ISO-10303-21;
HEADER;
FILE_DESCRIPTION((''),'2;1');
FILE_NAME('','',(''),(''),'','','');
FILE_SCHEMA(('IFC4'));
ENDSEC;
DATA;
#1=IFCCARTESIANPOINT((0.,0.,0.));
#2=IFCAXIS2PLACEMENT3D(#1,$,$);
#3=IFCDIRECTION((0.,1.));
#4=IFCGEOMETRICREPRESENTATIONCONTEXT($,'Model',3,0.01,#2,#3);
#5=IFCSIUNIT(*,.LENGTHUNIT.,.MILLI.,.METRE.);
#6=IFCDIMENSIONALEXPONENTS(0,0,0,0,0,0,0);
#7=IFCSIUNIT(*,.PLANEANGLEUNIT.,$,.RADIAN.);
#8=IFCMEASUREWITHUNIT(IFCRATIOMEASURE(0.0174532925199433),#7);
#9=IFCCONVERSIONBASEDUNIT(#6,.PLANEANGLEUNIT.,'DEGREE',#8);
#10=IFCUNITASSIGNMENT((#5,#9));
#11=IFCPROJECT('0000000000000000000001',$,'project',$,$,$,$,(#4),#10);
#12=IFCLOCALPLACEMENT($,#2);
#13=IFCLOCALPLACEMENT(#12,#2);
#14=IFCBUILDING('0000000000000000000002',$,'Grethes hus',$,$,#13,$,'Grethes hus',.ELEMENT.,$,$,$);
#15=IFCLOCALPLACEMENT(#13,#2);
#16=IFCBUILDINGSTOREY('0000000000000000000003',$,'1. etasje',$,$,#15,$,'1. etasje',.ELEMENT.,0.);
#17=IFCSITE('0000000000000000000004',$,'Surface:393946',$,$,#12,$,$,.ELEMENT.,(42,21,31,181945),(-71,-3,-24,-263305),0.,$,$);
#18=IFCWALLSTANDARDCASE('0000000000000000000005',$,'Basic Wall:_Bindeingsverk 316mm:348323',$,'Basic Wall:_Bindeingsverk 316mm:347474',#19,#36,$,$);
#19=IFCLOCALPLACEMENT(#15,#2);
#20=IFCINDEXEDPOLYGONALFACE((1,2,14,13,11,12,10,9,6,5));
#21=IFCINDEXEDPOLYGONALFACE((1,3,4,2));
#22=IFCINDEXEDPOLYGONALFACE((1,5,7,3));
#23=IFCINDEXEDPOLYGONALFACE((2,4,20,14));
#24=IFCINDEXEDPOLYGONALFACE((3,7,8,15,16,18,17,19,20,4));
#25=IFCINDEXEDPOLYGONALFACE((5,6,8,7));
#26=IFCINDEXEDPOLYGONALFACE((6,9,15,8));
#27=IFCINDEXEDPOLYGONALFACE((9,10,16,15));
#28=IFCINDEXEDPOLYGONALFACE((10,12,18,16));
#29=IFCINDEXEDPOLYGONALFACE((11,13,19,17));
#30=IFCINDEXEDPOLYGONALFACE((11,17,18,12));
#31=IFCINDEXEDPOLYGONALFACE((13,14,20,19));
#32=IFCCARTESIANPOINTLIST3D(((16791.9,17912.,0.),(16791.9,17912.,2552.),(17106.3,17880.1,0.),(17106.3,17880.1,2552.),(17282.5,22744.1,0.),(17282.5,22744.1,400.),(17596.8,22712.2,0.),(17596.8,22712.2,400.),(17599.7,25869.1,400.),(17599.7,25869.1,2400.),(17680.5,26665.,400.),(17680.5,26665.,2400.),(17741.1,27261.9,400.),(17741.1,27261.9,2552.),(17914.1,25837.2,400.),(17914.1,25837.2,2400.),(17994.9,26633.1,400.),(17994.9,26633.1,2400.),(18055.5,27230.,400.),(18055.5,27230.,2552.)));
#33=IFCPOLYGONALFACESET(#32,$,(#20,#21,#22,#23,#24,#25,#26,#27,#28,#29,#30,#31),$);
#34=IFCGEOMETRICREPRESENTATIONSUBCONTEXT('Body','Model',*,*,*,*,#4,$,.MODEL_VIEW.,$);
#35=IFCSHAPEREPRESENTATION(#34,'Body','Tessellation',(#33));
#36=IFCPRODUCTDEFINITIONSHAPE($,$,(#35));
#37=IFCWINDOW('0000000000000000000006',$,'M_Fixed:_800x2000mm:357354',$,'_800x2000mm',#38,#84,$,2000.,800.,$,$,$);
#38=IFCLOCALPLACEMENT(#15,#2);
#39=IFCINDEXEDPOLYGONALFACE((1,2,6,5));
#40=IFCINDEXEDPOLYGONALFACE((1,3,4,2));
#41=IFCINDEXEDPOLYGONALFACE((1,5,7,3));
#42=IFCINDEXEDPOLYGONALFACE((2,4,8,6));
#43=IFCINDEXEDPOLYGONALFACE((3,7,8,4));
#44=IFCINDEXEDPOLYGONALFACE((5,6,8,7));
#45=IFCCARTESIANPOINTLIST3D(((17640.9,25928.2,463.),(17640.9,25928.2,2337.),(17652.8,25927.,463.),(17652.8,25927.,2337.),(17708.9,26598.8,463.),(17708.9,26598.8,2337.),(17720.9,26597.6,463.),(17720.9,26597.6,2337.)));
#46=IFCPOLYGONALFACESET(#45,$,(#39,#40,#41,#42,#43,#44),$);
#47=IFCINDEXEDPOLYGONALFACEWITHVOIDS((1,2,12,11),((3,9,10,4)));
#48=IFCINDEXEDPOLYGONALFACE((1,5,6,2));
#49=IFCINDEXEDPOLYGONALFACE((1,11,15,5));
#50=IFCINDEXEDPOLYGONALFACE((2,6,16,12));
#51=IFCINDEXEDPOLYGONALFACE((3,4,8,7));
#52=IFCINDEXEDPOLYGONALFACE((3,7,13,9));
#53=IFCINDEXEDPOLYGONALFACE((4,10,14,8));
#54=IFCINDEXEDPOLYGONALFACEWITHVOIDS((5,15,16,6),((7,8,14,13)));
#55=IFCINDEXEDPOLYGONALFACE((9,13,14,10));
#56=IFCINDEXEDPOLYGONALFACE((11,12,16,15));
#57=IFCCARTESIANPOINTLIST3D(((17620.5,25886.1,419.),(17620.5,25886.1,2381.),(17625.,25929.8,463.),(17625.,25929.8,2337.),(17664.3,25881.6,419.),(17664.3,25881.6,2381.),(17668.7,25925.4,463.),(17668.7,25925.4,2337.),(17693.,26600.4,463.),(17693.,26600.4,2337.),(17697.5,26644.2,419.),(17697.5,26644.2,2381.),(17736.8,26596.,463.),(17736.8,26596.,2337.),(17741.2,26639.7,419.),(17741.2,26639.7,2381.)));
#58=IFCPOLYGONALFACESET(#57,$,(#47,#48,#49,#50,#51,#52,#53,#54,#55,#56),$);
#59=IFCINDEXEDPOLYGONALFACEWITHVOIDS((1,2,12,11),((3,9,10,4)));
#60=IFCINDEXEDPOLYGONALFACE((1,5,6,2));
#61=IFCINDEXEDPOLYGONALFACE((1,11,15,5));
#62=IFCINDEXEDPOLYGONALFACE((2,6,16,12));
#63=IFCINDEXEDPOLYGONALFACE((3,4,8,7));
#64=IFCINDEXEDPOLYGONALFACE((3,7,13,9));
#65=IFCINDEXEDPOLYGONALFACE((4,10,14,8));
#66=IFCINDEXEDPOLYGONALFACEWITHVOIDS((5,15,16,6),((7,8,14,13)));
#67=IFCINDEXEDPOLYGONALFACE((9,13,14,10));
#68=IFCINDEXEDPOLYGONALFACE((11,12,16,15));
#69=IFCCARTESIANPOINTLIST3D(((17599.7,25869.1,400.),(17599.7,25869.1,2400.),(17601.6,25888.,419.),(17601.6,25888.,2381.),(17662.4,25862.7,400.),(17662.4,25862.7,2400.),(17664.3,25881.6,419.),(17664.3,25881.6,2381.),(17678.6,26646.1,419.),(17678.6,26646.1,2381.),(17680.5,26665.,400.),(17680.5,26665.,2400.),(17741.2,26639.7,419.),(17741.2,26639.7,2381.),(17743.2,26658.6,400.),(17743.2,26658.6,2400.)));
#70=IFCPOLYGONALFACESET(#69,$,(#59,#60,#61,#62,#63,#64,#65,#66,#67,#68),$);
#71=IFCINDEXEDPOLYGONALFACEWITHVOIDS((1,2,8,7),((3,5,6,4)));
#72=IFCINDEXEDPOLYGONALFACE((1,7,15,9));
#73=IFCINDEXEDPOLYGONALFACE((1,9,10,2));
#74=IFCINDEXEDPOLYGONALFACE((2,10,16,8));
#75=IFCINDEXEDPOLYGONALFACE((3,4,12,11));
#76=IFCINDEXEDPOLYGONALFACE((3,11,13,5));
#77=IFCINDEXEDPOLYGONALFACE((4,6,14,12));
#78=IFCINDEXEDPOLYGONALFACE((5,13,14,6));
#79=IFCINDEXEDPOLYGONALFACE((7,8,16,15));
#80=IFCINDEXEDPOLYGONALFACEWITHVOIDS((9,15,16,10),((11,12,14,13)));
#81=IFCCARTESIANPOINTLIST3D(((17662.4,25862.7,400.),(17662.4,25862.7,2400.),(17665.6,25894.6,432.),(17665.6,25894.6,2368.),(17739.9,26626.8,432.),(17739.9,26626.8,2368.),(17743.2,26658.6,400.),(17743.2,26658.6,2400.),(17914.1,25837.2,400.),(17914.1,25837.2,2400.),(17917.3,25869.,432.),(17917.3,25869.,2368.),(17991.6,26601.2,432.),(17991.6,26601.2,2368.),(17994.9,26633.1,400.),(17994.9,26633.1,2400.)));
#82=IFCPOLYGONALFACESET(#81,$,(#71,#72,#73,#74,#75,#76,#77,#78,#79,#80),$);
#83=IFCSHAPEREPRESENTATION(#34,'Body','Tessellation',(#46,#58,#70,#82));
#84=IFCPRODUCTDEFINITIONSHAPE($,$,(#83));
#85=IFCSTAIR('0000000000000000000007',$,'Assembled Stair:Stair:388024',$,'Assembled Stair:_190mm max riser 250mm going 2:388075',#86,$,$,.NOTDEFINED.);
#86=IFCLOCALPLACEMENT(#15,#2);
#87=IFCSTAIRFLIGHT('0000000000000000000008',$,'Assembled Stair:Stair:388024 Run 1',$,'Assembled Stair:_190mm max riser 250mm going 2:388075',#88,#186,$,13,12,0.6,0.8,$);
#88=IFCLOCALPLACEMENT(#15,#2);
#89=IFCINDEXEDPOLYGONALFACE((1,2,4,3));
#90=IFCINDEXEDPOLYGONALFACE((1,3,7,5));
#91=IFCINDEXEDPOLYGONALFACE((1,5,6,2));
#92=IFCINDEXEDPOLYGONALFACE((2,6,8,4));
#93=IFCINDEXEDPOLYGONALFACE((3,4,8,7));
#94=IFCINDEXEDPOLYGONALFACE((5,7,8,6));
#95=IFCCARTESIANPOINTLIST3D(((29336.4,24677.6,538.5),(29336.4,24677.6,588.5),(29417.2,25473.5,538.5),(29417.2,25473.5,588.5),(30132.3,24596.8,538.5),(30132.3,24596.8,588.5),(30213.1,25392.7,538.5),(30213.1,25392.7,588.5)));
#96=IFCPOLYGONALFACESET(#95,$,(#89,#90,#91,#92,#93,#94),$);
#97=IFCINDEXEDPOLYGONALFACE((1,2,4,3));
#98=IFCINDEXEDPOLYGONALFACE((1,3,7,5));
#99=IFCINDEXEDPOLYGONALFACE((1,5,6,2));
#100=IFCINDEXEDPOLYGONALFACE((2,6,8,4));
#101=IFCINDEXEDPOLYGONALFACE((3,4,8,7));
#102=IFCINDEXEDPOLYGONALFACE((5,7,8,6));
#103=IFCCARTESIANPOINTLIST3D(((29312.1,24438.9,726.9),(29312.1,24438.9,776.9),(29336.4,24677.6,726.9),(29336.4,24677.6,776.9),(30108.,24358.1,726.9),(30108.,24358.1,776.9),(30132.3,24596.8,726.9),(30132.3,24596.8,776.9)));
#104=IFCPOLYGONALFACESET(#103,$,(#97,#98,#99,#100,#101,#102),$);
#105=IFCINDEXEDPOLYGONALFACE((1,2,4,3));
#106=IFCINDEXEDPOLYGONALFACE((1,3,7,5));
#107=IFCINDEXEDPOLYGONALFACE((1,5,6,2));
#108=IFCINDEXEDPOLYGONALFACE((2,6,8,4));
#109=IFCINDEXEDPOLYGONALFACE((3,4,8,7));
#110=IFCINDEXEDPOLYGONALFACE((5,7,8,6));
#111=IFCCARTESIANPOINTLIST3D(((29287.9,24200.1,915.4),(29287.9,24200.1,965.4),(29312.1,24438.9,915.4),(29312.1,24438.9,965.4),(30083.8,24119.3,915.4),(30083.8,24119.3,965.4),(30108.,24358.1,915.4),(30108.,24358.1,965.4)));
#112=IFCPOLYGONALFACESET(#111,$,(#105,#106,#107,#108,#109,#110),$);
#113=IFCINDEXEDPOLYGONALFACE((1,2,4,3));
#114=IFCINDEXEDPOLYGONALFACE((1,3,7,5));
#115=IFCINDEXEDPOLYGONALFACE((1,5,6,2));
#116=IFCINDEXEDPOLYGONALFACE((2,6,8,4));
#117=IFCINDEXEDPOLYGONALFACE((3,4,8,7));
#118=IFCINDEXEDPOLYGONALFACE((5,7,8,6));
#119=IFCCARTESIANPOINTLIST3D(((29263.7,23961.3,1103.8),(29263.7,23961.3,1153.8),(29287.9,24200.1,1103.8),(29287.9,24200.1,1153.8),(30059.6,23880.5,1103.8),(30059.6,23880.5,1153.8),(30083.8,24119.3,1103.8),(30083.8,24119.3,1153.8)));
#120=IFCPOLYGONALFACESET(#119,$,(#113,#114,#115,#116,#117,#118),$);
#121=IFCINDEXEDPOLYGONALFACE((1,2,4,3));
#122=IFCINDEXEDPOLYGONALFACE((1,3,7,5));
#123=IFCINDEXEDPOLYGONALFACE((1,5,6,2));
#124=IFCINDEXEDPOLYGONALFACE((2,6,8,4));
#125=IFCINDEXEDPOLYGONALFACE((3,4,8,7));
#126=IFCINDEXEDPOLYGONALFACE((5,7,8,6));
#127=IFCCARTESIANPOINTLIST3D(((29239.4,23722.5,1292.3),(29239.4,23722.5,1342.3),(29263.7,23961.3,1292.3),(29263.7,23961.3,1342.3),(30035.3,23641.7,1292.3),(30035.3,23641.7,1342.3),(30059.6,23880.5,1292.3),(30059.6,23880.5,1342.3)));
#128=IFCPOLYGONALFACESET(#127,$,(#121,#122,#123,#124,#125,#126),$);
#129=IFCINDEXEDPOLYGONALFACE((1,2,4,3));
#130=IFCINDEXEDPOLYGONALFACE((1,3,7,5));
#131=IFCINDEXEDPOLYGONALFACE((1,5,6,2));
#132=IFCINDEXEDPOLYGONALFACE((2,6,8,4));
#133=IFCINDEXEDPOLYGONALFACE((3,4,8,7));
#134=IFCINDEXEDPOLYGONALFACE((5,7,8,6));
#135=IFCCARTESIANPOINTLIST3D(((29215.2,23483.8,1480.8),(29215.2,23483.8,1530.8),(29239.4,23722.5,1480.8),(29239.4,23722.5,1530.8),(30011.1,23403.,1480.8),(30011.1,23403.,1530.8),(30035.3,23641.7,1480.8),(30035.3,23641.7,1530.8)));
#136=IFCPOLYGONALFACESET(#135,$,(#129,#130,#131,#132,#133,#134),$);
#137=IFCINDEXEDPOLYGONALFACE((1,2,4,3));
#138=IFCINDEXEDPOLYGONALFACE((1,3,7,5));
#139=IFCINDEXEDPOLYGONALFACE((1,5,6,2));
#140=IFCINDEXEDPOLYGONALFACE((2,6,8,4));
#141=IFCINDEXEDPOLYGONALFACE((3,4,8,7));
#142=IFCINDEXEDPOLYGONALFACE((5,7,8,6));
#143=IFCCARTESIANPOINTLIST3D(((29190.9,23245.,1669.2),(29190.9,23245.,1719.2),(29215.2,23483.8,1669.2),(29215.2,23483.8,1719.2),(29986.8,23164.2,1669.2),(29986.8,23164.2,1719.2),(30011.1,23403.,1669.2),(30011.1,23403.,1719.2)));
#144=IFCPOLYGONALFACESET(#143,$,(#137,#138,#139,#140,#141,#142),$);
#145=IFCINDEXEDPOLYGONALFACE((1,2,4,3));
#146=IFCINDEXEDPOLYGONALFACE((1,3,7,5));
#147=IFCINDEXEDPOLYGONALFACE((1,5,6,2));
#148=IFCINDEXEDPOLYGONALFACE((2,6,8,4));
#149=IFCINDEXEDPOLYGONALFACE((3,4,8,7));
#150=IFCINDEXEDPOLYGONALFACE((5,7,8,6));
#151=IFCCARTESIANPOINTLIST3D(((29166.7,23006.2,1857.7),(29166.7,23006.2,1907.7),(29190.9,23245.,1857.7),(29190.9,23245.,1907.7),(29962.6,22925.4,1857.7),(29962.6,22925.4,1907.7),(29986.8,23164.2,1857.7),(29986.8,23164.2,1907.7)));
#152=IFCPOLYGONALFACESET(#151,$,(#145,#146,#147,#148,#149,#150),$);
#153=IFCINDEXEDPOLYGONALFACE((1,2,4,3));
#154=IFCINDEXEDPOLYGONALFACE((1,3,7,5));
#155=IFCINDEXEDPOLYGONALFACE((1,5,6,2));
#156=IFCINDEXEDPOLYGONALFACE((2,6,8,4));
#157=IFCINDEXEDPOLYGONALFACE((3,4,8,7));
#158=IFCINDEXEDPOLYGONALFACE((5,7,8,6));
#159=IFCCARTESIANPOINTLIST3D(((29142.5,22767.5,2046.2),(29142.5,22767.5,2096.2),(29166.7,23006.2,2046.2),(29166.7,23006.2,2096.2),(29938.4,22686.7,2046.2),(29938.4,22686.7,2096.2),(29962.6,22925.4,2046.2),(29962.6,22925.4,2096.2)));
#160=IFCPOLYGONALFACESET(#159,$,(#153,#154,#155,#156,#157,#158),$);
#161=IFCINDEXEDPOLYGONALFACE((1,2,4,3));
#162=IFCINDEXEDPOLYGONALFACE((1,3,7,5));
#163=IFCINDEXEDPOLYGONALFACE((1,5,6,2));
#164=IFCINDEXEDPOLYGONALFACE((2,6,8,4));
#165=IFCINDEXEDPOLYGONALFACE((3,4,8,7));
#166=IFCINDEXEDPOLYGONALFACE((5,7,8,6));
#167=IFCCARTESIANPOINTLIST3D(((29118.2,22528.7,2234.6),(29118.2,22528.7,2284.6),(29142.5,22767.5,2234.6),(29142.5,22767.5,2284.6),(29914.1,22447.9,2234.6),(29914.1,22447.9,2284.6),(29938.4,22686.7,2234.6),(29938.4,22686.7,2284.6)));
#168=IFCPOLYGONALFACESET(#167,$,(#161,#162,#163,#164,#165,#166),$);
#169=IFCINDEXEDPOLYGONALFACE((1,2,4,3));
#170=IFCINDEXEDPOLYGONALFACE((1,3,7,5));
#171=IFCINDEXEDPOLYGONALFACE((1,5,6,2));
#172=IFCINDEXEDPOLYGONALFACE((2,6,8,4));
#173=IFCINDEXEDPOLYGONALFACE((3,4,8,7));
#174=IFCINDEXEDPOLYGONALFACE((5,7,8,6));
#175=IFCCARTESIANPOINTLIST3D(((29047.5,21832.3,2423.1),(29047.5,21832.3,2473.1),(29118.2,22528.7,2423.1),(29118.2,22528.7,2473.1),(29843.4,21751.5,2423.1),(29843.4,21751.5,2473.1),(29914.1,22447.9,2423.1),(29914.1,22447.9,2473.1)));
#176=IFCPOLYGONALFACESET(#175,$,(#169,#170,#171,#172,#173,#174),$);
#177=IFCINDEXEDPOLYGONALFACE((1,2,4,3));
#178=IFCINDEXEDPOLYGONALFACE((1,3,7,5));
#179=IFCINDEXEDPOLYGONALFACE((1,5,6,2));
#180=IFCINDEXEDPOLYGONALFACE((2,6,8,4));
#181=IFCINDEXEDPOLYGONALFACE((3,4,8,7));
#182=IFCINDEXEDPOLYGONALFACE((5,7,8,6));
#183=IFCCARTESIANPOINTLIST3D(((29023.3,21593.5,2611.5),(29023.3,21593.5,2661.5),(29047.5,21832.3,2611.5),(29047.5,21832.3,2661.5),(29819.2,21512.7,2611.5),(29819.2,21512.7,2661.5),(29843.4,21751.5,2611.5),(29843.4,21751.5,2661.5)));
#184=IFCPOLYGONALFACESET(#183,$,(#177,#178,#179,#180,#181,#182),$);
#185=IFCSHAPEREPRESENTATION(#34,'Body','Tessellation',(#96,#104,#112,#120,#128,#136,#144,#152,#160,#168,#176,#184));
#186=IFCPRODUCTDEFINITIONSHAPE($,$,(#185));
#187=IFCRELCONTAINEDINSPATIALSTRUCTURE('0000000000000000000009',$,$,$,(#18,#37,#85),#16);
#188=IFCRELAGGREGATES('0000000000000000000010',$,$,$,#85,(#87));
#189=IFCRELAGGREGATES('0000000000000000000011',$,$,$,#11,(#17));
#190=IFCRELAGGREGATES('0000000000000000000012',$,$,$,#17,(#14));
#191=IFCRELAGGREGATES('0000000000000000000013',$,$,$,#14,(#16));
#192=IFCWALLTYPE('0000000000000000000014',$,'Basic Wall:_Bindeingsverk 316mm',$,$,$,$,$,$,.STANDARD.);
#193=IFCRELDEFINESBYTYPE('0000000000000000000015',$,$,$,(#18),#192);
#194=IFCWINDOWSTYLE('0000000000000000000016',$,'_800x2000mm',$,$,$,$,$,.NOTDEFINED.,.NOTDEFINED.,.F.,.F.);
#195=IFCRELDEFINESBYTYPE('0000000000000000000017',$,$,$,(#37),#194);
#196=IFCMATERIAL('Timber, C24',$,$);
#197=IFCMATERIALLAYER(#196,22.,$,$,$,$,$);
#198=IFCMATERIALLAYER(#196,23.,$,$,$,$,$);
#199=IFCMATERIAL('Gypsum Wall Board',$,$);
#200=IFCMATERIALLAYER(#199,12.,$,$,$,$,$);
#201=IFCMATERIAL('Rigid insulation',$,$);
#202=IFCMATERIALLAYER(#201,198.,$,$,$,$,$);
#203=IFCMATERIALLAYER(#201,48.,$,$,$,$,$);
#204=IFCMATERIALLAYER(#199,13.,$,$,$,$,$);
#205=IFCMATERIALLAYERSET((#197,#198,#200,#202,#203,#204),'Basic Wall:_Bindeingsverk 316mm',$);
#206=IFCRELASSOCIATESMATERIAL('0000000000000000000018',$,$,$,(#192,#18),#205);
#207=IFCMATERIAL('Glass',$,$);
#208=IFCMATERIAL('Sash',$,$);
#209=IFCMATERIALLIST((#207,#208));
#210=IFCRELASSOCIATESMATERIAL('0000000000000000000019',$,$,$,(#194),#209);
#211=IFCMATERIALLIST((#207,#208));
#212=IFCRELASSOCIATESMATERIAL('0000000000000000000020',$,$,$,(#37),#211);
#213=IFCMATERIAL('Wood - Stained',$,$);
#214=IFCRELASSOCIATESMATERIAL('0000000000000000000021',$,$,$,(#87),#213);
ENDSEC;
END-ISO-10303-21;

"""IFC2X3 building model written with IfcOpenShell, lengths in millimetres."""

from ifc_helpers import new_model, entity, si_unit, converted_unit, direction, frame, frame_2d, origin, place, context, subcontext, project, spatial, polyline, rectangle, outline, extrude, clip, bounded_halfspace, source, transform, mapped, material, material_list, layer, layer_set, layer_usage, type_object, type_shapes, element, fill, aggregate, save


model = new_model("IFC2X3")

# Units and contexts
model_context = context("Model", 3, precision=0.01, world=origin(), true_north=direction((0.0, 1.0)))
body_context = subcontext(model_context, "Body", "Model", "MODEL_VIEW")
ifc_project = project(units=[si_unit("LENGTHUNIT", "METRE", prefix="MILLI"), converted_unit("PLANEANGLEUNIT", "DEGREE", entity("IfcRatioMeasure", 0.0174532925199433), si_unit("PLANEANGLEUNIT", "RADIAN"), dimensions=[0, 0, 0, 0, 0, 0, 0])], contexts=[model_context])

# Site, building, storey
site_placement = place(None, origin())
site = spatial("IfcSite", under=ifc_project, at=site_placement, Name="Surface:393946", CompositionType="ELEMENT", RefLatitude=(42, 21, 31, 181945), RefLongitude=(-71, -3, -24, -263305), RefElevation=0.0)
building_placement = place(site_placement, origin())
building = spatial("IfcBuilding", under=site, at=building_placement, Name="Grethes hus", LongName="Grethes hus", CompositionType="ELEMENT")
storey_placement = place(building_placement, origin())
storey = spatial("IfcBuildingStorey", under=building, at=storey_placement, Name="1. etasje", LongName="1. etasje", CompositionType="ELEMENT", Elevation=0.0)

# Shared definitions
ifc_material_1 = material(Name="Timber, C24")
ifc_layer_1 = layer(ifc_material_1, 22.0)
ifc_layer_2 = layer(ifc_material_1, 23.0)
ifc_material_2 = material(Name="Gypsum Wall Board")
ifc_layer_3 = layer(ifc_material_2, 12.0)
ifc_material_3 = material(Name="Rigid insulation")
ifc_layer_4 = layer(ifc_material_3, 198.0)
ifc_layer_5 = layer(ifc_material_3, 48.0)
ifc_layer_6 = layer(ifc_material_2, 13.0)
ifc_layer_set_1 = layer_set([ifc_layer_1, ifc_layer_2, ifc_layer_3, ifc_layer_4, ifc_layer_5, ifc_layer_6], Name="Basic Wall:_Bindeingsverk 316mm")
wall_type_1 = type_object("IfcWallType", Name="Basic Wall:_Bindeingsverk 316mm", PredefinedType="STANDARD", material=ifc_layer_set_1)
ifc_material_4 = material(Name="Glass")
ifc_material_5 = material(Name="Sash")

# Wall, openings, window
ifc_layer_usage_1 = layer_usage(ifc_layer_set_1, "AXIS2", "NEGATIVE", 158.0)
wall_1_placement = place(storey_placement, frame((16949.1, 17896.0, 0.0), z_axis=(0.0, 0.0, 1.0), x_axis=(0.100996, 0.994887, 0.0)))
wall_1 = element("IfcWallStandardCase", 1, at=wall_1_placement, inside=storey, type_object=wall_type_1, material=ifc_layer_usage_1, Name="Basic Wall:_Bindeingsverk 316mm:348323", ObjectType="Basic Wall:_Bindeingsverk 316mm:347474", context=body_context, shape_type="Clipping", body=[
    clip(extrude(rectangle(XDim=9398.0, YDim=316.0, at=frame_2d((4699.0, 0.0), x_axis=(-1.0, 0.0))), origin(), (0.0, 0.0, 1.0), 2552.0), bounded_halfspace(frame((0.0, -158.0, 2552.0), z_axis=(0.0, 0.0, -1.0), x_axis=(0.0, -1.0, 0.0)), True, frame((0.0, -158.0, 2552.0)), polyline([(0.0, 0.0), (316.0, 0.0), (9398.0, 0.0), (9398.0, 61.0), (0.0, 61.0), (0.0, 0.0)]))),
])
opening_1_placement = place(wall_1_placement, origin())
element("IfcOpeningElement", 2, at=opening_1_placement, cuts=wall_1, ObjectType="Opening", context=body_context, shape_type="SweptSolid", body=[
    extrude(rectangle(XDim=400.0, YDim=4699.0, at=frame_2d((0.0, 0.0), x_axis=(0.0, 1.0))), frame((7206.5, 158.0, 200.0), z_axis=(0.0, -1.0, 0.0), x_axis=(-1.0, 0.0, 0.0)), (0.0, 0.0, 1.0), 316.0),
])
opening_2_placement = place(wall_1_placement, frame((7998.0, -158.0, 400.0)))
opening_2 = element("IfcOpeningElement", 3, at=opening_2_placement, cuts=wall_1, ObjectType="Opening", context=body_context, shape_type="SweptSolid", body=[
    extrude(rectangle(XDim=2000.0, YDim=800.0, at=frame_2d((1000.0, 400.0), x_axis=(1.0, 0.0))), frame((0.0, 0.0, 0.0), z_axis=(0.0, 1.0, 0.0), x_axis=(0.0, 0.0, 1.0)), (0.0, 0.0, 1.0), 316.0),
])
ifc_material_list_1 = material_list([ifc_material_4, ifc_material_5])
ifc_material_list_2 = material_list([ifc_material_4, ifc_material_5])
window_style_1 = type_object("IfcWindowStyle", Name="_800x2000mm", ConstructionType="NOTDEFINED", OperationType="NOTDEFINED", ParameterTakesPrecedence=False, Sizeable=False, material=ifc_material_list_2)
shared_shape_1 = source(origin(), body_context, "Body", "SweptSolid", [
    extrude(rectangle(XDim=12.0, YDim=674.0, at=frame_2d((0.0, 0.0), x_axis=(1.0, 0.0))), frame((400.0, 275.0, 63.0), z_axis=(0.0, 0.0, 1.0), x_axis=(0.0, -1.0, 0.0)), (0.0, 0.0, 1.0), 1874.0),
    extrude(outline(polyline([(-381.0, -981.0), (381.0, -981.0), (381.0, 981.0), (-381.0, 981.0), (-381.0, -981.0)]), holes=[polyline([(-337.0, -937.0), (-337.0, 937.0), (337.0, 937.0), (337.0, -937.0), (-337.0, -937.0)])]), frame((400.0, 253.0, 1000.0), z_axis=(0.0, 1.0, 0.0), x_axis=(1.0, 0.0, 0.0)), (0.0, 0.0, 1.0), 44.0),
    extrude(outline(polyline([(-400.0, -1000.0), (400.0, -1000.0), (400.0, 1000.0), (-400.0, 1000.0), (-400.0, -1000.0)]), holes=[polyline([(-381.0, -981.0), (-381.0, 981.0), (381.0, 981.0), (381.0, -981.0), (-381.0, -981.0)])]), frame((400.0, 253.0, 1000.0), z_axis=(0.0, 1.0, 0.0), x_axis=(1.0, 0.0, 0.0)), (0.0, 0.0, 1.0), 63.0),
    extrude(outline(polyline([(-400.0, -1000.0), (400.0, -1000.0), (400.0, 1000.0), (-400.0, 1000.0), (-400.0, -1000.0)]), holes=[polyline([(-368.0, -968.0), (-368.0, 968.0), (368.0, 968.0), (368.0, -968.0), (-368.0, -968.0)])]), frame((400.0, 0.0, 1000.0), z_axis=(0.0, 1.0, 0.0), x_axis=(1.0, 0.0, 0.0)), (0.0, 0.0, 1.0), 253.0),
])
type_shapes(window_style_1, [shared_shape_1])
window_1_placement = place(opening_2_placement, origin())
window_1 = element("IfcWindow", 4, at=window_1_placement, inside=storey, type_object=window_style_1, material=ifc_material_list_1, Name="M_Fixed:_800x2000mm:357354", ObjectType="_800x2000mm", OverallHeight=2000.0, OverallWidth=800.0, context=body_context, shape_type="MappedRepresentation", body=[
    mapped(shared_shape_1, transform((0.0, 0.0, 0.0), scale=1.0)),
])
fill(opening_2, window_1)

# Stair, stair flight
stair_1_placement = place(storey_placement, origin())
stair_1 = element("IfcStair", 5, at=stair_1_placement, inside=storey, Name="Assembled Stair:Stair:388024", ObjectType="Assembled Stair:_190mm max riser 250mm going 2:388075", ShapeType="NOTDEFINED")
ifc_material_6 = material(Name="Wood - Stained")
stair_flight_1_placement = place(stair_1_placement, origin())
stair_flight_1 = element("IfcStairFlight", 6, at=stair_flight_1_placement, material=ifc_material_6, Name="Assembled Stair:Stair:388024 Run 1", ObjectType="Assembled Stair:_190mm max riser 250mm going 2:388075", NumberOfRiser=13, NumberOfTreads=12, RiserHeight=0.6, TreadLength=0.8, context=body_context, shape_type="SweptSolid", body=[
    extrude(rectangle(XDim=800.0, YDim=800.0, at=frame_2d((0.0, 0.0), x_axis=(1.0, 0.0))), frame((29774.7, 25035.2, 538.5), z_axis=(0.0, 0.0, 1.0), x_axis=(0.100996, 0.994887, 0.0)), (0.0, 0.0, 1.0), 50.0),
    extrude(rectangle(XDim=240.0, YDim=800.0, at=frame_2d((0.0, 0.0), x_axis=(1.0, 0.0))), frame((29722.2, 24517.9, 726.9), z_axis=(0.0, 0.0, 1.0), x_axis=(0.100996, 0.994887, 0.0)), (0.0, 0.0, 1.0), 50.0),
    extrude(rectangle(XDim=240.0, YDim=800.0, at=frame_2d((0.0, 0.0), x_axis=(1.0, 0.0))), frame((29698.0, 24279.1, 915.4), z_axis=(0.0, 0.0, 1.0), x_axis=(0.100996, 0.994887, 0.0)), (0.0, 0.0, 1.0), 50.0),
    extrude(rectangle(XDim=240.0, YDim=800.0, at=frame_2d((0.0, 0.0), x_axis=(1.0, 0.0))), frame((29673.7, 24040.3, 1103.8), z_axis=(0.0, 0.0, 1.0), x_axis=(0.100996, 0.994887, 0.0)), (0.0, 0.0, 1.0), 50.0),
    extrude(rectangle(XDim=240.0, YDim=800.0, at=frame_2d((0.0, 0.0), x_axis=(1.0, 0.0))), frame((29649.5, 23801.5, 1292.3), z_axis=(0.0, 0.0, 1.0), x_axis=(0.100996, 0.994887, 0.0)), (0.0, 0.0, 1.0), 50.0),
    extrude(rectangle(XDim=240.0, YDim=800.0, at=frame_2d((0.0, 0.0), x_axis=(1.0, 0.0))), frame((29625.2, 23562.8, 1480.8), z_axis=(0.0, 0.0, 1.0), x_axis=(0.100996, 0.994887, 0.0)), (0.0, 0.0, 1.0), 50.0),
    extrude(rectangle(XDim=240.0, YDim=800.0, at=frame_2d((0.0, 0.0), x_axis=(1.0, 0.0))), frame((29601.0, 23324.0, 1669.2), z_axis=(0.0, 0.0, 1.0), x_axis=(0.100996, 0.994887, 0.0)), (0.0, 0.0, 1.0), 50.0),
    extrude(rectangle(XDim=240.0, YDim=800.0, at=frame_2d((0.0, 0.0), x_axis=(1.0, 0.0))), frame((29576.8, 23085.2, 1857.7), z_axis=(0.0, 0.0, 1.0), x_axis=(0.100996, 0.994887, 0.0)), (0.0, 0.0, 1.0), 50.0),
    extrude(rectangle(XDim=240.0, YDim=800.0, at=frame_2d((0.0, 0.0), x_axis=(1.0, 0.0))), frame((29552.5, 22846.4, 2046.2), z_axis=(0.0, 0.0, 1.0), x_axis=(0.100996, 0.994887, 0.0)), (0.0, 0.0, 1.0), 50.0),
    extrude(rectangle(XDim=240.0, YDim=800.0, at=frame_2d((0.0, 0.0), x_axis=(1.0, 0.0))), frame((29528.3, 22607.7, 2234.6), z_axis=(0.0, 0.0, 1.0), x_axis=(0.100996, 0.994887, 0.0)), (0.0, 0.0, 1.0), 50.0),
    extrude(rectangle(XDim=700.0, YDim=800.0, at=frame_2d((0.0, 0.0), x_axis=(1.0, 0.0))), frame((29480.8, 22140.1, 2423.1), z_axis=(0.0, 0.0, 1.0), x_axis=(0.100996, 0.994887, 0.0)), (0.0, 0.0, 1.0), 50.0),
    extrude(rectangle(XDim=240.0, YDim=800.0, at=frame_2d((0.0, 0.0), x_axis=(1.0, 0.0))), frame((29433.4, 21672.5, 2611.5), z_axis=(0.0, 0.0, 1.0), x_axis=(0.100996, 0.994887, 0.0)), (0.0, 0.0, 1.0), 50.0),
])
aggregate(stair_1, [stair_flight_1])

save(model, "model.ifc")
